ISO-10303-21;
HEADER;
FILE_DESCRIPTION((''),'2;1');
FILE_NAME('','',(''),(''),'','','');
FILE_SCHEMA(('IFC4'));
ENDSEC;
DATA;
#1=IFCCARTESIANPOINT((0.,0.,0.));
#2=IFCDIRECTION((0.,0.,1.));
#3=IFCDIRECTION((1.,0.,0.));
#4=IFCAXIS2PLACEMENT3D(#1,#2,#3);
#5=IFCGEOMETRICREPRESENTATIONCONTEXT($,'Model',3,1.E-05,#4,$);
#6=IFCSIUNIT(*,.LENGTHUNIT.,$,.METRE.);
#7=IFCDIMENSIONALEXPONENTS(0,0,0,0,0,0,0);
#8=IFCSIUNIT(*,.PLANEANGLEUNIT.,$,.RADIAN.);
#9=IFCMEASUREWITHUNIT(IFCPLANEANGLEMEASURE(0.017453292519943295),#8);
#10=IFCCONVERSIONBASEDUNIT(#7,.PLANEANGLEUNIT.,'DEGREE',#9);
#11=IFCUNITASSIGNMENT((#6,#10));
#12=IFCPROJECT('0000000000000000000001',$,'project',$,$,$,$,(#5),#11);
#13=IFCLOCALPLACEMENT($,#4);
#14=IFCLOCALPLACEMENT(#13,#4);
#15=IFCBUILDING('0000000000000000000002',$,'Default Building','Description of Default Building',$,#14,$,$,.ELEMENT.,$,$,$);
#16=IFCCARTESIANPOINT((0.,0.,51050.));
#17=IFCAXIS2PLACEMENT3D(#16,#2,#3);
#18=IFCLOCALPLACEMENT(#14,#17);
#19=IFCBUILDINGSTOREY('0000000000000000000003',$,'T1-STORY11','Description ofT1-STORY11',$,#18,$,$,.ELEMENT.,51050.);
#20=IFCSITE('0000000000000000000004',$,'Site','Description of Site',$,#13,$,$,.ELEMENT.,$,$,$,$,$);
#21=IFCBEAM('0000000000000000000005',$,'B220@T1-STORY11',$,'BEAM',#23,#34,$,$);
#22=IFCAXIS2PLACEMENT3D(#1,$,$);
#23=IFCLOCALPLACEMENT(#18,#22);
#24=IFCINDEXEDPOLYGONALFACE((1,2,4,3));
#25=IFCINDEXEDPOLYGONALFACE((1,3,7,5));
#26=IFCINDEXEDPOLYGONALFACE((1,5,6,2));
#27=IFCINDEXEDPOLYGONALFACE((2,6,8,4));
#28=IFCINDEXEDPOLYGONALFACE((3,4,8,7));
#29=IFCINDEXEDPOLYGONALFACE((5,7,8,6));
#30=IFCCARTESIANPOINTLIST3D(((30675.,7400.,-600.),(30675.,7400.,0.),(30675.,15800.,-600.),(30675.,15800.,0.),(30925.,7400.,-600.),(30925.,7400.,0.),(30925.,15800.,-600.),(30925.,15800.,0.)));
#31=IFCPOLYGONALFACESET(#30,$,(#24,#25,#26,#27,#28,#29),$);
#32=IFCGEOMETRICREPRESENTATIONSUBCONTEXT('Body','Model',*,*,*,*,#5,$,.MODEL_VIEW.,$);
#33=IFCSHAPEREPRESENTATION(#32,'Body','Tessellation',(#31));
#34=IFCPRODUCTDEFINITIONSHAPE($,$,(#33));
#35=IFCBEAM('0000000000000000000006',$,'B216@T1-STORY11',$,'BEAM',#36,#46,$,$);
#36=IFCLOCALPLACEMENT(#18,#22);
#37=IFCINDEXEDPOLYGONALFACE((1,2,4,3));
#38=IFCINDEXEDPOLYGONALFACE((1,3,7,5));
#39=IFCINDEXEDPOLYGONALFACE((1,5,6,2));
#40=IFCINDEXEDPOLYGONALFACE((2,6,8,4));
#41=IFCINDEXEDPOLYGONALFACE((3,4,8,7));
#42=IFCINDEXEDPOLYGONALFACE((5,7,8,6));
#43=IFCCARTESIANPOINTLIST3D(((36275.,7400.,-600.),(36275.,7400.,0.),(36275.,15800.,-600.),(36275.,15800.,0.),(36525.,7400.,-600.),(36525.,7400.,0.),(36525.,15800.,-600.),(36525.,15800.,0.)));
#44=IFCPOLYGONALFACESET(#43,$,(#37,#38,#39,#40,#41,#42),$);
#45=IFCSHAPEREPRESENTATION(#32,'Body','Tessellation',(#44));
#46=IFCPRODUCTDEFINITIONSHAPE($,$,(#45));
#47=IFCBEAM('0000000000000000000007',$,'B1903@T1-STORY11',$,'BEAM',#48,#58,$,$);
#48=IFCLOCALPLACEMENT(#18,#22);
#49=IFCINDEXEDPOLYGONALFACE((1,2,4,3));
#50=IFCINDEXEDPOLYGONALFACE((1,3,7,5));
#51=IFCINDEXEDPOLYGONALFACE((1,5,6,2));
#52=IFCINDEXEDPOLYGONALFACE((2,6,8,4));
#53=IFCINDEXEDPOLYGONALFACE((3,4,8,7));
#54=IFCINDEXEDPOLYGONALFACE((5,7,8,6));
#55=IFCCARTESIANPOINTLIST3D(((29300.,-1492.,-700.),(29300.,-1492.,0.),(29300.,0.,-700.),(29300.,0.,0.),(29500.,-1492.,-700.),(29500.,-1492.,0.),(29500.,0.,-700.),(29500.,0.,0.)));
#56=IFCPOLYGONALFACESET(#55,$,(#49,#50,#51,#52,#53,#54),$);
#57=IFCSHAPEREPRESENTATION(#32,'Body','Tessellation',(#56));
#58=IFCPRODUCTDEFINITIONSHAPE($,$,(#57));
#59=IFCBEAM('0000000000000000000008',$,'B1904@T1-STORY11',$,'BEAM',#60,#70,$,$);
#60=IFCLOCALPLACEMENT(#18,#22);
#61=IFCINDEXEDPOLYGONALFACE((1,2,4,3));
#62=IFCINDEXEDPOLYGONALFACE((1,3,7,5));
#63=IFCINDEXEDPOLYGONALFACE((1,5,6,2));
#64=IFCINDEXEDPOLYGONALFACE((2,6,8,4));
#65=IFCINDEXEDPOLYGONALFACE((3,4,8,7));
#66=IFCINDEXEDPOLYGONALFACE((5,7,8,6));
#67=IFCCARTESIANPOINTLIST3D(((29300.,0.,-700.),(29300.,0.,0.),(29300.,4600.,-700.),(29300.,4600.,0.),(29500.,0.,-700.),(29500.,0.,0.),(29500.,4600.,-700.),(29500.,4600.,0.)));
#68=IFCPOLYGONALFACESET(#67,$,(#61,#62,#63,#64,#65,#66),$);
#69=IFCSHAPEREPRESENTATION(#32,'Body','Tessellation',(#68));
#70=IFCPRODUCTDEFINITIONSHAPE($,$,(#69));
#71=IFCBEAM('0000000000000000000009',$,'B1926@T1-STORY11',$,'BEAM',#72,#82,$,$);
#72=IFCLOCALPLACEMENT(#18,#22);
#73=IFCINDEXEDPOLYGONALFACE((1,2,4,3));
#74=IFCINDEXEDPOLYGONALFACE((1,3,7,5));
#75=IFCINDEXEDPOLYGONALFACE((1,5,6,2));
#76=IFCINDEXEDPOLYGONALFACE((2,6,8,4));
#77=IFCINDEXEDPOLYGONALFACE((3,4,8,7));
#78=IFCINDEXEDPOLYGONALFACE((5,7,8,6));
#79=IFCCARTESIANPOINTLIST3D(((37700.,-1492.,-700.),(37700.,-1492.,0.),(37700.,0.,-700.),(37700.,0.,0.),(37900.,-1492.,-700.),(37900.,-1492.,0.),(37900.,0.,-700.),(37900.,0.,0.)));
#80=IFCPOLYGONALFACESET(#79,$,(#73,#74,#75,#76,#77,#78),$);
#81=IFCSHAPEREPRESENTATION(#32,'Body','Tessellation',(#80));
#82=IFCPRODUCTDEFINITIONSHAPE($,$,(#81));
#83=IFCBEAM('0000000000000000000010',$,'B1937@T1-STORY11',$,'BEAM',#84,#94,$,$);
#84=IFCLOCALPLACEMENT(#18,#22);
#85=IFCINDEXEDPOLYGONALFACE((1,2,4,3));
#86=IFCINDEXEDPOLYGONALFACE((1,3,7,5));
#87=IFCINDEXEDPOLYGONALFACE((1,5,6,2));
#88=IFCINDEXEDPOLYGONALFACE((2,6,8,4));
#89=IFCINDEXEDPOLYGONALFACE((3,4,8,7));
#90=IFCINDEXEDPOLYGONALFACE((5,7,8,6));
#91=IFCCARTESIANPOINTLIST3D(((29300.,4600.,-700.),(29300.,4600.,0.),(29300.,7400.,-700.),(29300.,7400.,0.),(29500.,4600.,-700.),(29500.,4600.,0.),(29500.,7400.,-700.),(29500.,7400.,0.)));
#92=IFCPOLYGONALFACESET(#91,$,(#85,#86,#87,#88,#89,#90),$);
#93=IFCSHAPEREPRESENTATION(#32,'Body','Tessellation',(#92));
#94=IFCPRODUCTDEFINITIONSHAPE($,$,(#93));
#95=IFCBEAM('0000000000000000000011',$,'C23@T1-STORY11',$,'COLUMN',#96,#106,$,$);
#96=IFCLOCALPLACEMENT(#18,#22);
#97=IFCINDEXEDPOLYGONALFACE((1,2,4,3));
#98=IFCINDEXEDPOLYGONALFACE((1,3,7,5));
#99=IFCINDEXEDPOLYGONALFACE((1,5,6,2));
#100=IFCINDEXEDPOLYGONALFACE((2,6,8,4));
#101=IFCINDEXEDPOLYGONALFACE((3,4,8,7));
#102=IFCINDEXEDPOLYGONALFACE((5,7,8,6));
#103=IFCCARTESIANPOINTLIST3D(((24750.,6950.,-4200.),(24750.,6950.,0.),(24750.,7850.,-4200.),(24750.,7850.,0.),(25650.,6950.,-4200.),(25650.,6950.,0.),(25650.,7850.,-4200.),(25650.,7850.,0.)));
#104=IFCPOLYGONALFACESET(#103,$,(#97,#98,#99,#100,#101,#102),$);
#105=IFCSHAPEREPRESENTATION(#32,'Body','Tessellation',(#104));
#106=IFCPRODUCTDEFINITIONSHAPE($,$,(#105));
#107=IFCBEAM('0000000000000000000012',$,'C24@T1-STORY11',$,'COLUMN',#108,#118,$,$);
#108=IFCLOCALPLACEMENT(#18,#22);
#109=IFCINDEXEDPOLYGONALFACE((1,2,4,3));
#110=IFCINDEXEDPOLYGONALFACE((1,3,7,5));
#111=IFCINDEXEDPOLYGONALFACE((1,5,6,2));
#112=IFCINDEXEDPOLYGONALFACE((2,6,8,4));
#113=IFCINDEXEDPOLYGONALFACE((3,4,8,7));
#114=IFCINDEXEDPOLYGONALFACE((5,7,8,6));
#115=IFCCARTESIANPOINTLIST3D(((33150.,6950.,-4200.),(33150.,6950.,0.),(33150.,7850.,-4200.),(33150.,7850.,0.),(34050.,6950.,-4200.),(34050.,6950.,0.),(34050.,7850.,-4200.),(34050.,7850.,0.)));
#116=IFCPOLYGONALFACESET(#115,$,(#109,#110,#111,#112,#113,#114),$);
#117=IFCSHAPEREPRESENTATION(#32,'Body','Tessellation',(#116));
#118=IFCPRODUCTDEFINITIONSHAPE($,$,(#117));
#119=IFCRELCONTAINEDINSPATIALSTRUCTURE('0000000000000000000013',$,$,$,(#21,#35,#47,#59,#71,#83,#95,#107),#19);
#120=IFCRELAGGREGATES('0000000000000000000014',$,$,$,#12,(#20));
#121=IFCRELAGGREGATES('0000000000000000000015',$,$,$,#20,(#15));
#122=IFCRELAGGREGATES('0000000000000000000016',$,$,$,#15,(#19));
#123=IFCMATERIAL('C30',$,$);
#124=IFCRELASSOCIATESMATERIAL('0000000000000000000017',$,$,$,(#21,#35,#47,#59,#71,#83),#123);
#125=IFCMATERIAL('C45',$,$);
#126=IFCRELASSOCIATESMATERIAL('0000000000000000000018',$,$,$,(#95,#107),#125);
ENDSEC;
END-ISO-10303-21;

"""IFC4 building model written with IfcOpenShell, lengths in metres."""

from ifc_helpers import new_model, entity, si_unit, converted_unit, frame, origin_with_axes, place, context, subcontext, project, spatial, rectangle, extrude, material, element, save


model = new_model("IFC4")

# Units and contexts
model_context = context("Model", 3, precision=1e-05, world=origin_with_axes())
body_context = subcontext(model_context, "Body", "Model", "MODEL_VIEW")
ifc_project = project(units=[si_unit("LENGTHUNIT", "METRE"), converted_unit("PLANEANGLEUNIT", "DEGREE", entity("IfcPlaneAngleMeasure", 0.017453292519943295), si_unit("PLANEANGLEUNIT", "RADIAN"), dimensions=[0, 0, 0, 0, 0, 0, 0])], contexts=[model_context])

# Site, building, storey
site_placement = place(None, origin_with_axes())
site = spatial("IfcSite", under=ifc_project, at=site_placement, Name="Site", Description="Description of Site", CompositionType="ELEMENT")
building_placement = place(site_placement, origin_with_axes())
building = spatial("IfcBuilding", under=site, at=building_placement, Name="Default Building", Description="Description of Default Building", CompositionType="ELEMENT")
storey_placement = place(building_placement, frame((0.0, 0.0, 51050.0), z_axis=(0.0, 0.0, 1.0), x_axis=(1.0, 0.0, 0.0)))
storey = spatial("IfcBuildingStorey", under=building, at=storey_placement, Name="T1-STORY11", Description="Description ofT1-STORY11", CompositionType="ELEMENT", Elevation=51050.0)

# Beams
ifc_material_1 = material(Name="C30")
for number, where, z_axis, x_axis, name in (
    (1, (30800.0, 7400.0, -300.0), (0.0, 1.0, 0.0), (-1.0, 0.0, 0.0), "B220@T1-STORY11"),
    (2, (36400.0, 7400.0, -300.0), (0.0, 1.0, 0.0), (-1.0, 0.0, 0.0), "B216@T1-STORY11"),
):
    element("IfcBeam", number, at=place(storey_placement, frame(where, z_axis=z_axis, x_axis=x_axis)), inside=storey, material=ifc_material_1, Name=name, ObjectType="BEAM", context=body_context, shape_type="SweptSolid", body=[
        extrude(rectangle(XDim=250.0, YDim=600.0), origin_with_axes(), (0.0, 0.0, 1.0), 8400.0),
    ])
beam_1_placement = place(storey_placement, frame((29400.0, -1492.0, -350.0), z_axis=(0.0, 1.0, 0.0), x_axis=(-1.0, 0.0, 0.0)))
element("IfcBeam", 3, at=beam_1_placement, inside=storey, material=ifc_material_1, Name="B1903@T1-STORY11", ObjectType="BEAM", context=body_context, shape_type="SweptSolid", body=[
    extrude(rectangle(XDim=200.0, YDim=700.0), origin_with_axes(), (0.0, 0.0, 1.0), 1492.0),
])
beam_2_placement = place(storey_placement, frame((29400.0, 0.0, -350.0), z_axis=(0.0, 1.0, 0.0), x_axis=(-1.0, 0.0, 0.0)))
element("IfcBeam", 4, at=beam_2_placement, inside=storey, material=ifc_material_1, Name="B1904@T1-STORY11", ObjectType="BEAM", context=body_context, shape_type="SweptSolid", body=[
    extrude(rectangle(XDim=200.0, YDim=700.0), origin_with_axes(), (0.0, 0.0, 1.0), 4600.0),
])
beam_3_placement = place(storey_placement, frame((37800.0, -1492.0, -350.0), z_axis=(0.0, 1.0, 0.0), x_axis=(-1.0, 0.0, 0.0)))
element("IfcBeam", 5, at=beam_3_placement, inside=storey, material=ifc_material_1, Name="B1926@T1-STORY11", ObjectType="BEAM", context=body_context, shape_type="SweptSolid", body=[
    extrude(rectangle(XDim=200.0, YDim=700.0), origin_with_axes(), (0.0, 0.0, 1.0), 1492.0),
])
beam_4_placement = place(storey_placement, frame((29400.0, 4600.0, -350.0), z_axis=(0.0, 1.0, 0.0), x_axis=(-1.0, 0.0, 0.0)))
element("IfcBeam", 6, at=beam_4_placement, inside=storey, material=ifc_material_1, Name="B1937@T1-STORY11", ObjectType="BEAM", context=body_context, shape_type="SweptSolid", body=[
    extrude(rectangle(XDim=200.0, YDim=700.0), origin_with_axes(), (0.0, 0.0, 1.0), 2800.0),
])
ifc_material_2 = material(Name="C45")
for number, where, z_axis, x_axis, name in (
    (7, (25200.0, 7400.0, -4200.0), (0.0, 0.0, 1.0), (-1.0, 0.0, 0.0), "C23@T1-STORY11"),
    (8, (33600.0, 7400.0, -4200.0), (0.0, 0.0, 1.0), (-1.0, 0.0, 0.0), "C24@T1-STORY11"),
):
    element("IfcBeam", number, at=place(storey_placement, frame(where, z_axis=z_axis, x_axis=x_axis)), inside=storey, material=ifc_material_2, Name=name, ObjectType="COLUMN", context=body_context, shape_type="SweptSolid", body=[
        extrude(rectangle(XDim=900.0, YDim=900.0), origin_with_axes(), (0.0, 0.0, 1.0), 4200.0),
    ])

save(model, "model.ifc")
